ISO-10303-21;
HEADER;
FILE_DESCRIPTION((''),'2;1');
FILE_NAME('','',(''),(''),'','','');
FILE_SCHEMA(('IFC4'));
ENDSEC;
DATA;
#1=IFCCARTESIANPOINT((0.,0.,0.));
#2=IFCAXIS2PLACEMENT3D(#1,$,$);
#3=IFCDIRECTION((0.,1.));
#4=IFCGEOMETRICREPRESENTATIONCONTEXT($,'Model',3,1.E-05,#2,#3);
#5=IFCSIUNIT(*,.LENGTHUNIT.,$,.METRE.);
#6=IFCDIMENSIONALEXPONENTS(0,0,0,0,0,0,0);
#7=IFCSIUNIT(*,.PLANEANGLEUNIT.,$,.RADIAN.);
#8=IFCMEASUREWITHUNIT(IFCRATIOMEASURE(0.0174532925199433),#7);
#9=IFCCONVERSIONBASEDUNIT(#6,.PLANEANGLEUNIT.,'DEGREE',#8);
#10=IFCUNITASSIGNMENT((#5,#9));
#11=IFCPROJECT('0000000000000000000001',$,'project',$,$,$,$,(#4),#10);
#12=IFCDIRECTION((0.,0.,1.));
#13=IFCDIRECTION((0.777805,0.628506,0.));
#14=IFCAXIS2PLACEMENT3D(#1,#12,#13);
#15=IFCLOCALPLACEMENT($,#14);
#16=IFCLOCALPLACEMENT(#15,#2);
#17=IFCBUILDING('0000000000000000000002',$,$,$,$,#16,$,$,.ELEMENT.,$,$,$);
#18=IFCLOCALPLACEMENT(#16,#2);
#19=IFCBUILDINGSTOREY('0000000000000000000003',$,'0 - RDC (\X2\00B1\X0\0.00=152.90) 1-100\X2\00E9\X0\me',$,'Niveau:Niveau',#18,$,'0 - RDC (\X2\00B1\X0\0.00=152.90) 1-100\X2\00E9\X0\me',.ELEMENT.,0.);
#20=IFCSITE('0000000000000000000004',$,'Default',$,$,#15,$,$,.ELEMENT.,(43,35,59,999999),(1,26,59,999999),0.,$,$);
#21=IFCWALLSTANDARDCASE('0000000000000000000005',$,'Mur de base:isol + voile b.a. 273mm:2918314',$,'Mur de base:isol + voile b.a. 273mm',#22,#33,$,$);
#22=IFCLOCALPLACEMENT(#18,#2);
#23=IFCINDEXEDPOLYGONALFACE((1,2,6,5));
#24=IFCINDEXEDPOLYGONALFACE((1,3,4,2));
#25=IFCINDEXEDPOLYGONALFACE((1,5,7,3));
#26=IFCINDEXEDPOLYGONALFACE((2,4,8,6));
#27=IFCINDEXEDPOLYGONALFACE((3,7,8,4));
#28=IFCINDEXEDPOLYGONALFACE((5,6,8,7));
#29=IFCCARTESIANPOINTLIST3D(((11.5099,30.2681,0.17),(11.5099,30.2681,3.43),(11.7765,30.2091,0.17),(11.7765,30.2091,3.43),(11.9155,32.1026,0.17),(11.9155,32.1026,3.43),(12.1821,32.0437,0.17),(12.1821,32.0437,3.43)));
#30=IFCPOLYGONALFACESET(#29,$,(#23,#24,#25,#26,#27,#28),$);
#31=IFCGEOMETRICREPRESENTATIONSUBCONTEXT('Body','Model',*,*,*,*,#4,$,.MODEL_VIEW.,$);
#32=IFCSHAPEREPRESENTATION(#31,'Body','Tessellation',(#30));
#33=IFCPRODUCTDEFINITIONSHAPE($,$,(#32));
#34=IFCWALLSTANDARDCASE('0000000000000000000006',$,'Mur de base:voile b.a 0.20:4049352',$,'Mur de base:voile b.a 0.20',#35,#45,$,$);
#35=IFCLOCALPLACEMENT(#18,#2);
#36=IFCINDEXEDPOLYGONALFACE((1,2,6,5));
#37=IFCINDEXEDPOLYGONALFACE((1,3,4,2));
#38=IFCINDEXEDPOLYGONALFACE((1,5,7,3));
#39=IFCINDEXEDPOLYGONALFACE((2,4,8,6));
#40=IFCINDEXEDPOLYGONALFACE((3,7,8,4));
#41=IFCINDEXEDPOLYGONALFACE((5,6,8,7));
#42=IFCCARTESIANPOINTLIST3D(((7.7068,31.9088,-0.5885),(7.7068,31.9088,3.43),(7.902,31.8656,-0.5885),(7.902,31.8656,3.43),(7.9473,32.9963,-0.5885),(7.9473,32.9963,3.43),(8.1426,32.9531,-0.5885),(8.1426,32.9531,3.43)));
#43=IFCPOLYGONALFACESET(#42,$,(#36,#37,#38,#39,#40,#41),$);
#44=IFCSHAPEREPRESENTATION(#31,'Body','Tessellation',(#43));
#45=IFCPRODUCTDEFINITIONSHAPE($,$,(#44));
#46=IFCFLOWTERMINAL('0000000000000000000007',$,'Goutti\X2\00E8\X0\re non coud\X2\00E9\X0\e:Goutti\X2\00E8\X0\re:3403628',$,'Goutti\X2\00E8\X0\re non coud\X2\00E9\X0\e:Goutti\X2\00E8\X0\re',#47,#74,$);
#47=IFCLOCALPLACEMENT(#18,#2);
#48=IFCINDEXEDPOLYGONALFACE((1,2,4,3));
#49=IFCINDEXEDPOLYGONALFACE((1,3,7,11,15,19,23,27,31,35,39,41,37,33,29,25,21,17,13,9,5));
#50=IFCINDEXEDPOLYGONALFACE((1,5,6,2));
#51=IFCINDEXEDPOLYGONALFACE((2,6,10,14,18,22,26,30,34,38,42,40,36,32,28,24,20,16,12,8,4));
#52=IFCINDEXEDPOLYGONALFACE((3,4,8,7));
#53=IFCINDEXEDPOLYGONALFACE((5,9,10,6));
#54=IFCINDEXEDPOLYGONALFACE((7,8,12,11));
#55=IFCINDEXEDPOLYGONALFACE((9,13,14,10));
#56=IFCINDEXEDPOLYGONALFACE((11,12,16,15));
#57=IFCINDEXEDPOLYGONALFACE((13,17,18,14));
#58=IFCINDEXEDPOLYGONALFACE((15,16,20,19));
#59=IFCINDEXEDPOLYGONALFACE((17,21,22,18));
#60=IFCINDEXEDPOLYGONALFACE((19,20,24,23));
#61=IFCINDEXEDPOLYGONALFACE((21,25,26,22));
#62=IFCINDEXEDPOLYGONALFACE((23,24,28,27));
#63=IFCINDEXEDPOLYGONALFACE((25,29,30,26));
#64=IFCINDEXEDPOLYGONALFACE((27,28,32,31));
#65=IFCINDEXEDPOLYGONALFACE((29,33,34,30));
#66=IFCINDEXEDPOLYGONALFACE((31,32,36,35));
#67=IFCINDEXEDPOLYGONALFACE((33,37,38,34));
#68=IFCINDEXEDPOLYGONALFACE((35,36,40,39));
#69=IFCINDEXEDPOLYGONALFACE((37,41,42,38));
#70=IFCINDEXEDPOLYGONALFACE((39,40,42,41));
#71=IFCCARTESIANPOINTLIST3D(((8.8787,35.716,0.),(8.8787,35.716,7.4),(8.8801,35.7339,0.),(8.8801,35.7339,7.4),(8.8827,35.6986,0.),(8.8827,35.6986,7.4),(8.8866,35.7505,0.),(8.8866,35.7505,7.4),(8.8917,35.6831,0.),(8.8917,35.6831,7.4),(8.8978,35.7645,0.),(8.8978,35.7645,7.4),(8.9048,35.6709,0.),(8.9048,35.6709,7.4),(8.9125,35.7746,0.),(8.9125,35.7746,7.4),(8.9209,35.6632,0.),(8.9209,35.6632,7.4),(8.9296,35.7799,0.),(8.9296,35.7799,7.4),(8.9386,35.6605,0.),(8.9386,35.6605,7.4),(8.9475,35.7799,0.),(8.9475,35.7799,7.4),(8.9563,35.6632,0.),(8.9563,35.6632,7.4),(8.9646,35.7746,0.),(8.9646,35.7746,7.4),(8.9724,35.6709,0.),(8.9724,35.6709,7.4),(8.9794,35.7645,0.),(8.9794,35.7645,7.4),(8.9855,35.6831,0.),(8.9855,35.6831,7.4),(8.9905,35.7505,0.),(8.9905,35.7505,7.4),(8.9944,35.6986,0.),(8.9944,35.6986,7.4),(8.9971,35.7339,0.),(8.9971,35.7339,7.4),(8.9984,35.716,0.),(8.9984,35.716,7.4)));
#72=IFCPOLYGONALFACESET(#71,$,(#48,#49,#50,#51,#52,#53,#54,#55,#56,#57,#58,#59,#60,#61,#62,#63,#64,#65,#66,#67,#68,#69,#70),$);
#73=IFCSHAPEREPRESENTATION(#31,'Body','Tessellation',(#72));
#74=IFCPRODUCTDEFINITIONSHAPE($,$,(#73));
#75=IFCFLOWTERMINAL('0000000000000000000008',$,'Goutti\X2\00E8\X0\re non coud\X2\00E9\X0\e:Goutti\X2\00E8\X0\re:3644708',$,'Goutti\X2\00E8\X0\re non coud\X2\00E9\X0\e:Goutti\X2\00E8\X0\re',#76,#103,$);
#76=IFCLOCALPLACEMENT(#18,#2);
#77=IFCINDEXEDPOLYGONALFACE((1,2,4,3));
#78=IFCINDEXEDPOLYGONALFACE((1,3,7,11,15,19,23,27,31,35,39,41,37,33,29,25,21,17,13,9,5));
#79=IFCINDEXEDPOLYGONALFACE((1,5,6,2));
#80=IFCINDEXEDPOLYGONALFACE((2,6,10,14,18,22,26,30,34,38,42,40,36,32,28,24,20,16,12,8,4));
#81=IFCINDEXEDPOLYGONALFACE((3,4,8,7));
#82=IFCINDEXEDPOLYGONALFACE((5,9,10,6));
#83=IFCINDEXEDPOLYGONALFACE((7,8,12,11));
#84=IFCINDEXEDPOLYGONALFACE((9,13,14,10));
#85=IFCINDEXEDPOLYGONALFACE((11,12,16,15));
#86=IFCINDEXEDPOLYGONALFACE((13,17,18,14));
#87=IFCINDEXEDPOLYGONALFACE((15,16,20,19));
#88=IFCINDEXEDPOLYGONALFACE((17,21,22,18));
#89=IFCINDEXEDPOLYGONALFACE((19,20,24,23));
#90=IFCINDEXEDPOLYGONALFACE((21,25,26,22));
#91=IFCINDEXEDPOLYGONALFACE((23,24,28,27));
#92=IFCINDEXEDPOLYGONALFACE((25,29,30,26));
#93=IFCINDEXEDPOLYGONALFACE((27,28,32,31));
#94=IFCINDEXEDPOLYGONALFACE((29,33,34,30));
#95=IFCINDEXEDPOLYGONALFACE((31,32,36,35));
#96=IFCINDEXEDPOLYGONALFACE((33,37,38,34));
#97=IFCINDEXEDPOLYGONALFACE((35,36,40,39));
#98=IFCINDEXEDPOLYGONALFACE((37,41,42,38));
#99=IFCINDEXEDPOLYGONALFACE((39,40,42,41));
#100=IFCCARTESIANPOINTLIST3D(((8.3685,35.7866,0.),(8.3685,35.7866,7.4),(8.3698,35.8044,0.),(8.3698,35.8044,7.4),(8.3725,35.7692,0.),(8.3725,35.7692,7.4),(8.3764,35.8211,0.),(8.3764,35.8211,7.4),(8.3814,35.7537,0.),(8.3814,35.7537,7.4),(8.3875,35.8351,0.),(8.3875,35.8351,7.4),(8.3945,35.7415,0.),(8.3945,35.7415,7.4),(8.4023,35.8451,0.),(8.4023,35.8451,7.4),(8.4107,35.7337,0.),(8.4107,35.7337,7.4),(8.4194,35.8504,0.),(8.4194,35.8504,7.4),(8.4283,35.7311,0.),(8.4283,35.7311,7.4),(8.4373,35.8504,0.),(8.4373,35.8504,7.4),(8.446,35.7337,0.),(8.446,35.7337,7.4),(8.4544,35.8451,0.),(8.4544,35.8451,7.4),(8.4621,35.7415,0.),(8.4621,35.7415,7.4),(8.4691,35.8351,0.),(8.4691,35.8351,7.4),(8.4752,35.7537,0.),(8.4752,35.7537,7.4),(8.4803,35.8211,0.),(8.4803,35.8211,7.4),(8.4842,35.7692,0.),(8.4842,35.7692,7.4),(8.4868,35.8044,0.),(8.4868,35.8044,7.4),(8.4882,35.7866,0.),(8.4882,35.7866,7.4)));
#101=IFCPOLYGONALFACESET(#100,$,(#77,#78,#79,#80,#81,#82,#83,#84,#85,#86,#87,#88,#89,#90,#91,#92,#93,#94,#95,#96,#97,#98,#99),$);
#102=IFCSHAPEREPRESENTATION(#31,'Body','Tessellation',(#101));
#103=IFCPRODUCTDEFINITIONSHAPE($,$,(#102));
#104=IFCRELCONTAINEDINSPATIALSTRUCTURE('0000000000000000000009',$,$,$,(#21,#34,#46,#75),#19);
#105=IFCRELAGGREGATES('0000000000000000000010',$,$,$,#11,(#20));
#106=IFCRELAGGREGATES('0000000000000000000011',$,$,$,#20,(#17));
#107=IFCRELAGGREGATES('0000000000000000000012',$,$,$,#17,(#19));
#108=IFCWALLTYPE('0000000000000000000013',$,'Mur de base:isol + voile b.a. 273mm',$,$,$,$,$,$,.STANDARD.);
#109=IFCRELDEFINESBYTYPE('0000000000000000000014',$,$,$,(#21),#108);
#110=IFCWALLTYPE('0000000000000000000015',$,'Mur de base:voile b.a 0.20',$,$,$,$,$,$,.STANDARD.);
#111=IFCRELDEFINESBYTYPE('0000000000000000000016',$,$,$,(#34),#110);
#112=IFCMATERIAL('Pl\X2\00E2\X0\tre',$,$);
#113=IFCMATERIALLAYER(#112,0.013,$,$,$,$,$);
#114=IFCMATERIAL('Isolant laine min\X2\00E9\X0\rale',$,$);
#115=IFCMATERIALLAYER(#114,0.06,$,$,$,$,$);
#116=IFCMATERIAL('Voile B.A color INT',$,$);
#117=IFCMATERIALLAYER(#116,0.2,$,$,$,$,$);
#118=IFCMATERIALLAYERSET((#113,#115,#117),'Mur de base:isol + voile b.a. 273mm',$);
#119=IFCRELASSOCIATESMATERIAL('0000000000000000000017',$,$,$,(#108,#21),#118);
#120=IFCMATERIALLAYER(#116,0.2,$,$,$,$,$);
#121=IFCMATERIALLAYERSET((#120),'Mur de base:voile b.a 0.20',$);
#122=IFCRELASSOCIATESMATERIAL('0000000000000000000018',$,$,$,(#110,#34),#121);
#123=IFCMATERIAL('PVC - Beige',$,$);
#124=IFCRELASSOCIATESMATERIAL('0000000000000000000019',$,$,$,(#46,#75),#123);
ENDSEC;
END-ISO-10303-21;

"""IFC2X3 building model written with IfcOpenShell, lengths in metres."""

from ifc_helpers import new_model, entity, si_unit, converted_unit, direction, frame, frame_2d, origin, place, context, subcontext, project, spatial, polyline, rectangle, circle, outline, extrude, clip, bounded_halfspace, source, transform, mapped, material, layer, layer_set, layer_usage, type_object, element, save


model = new_model("IFC2X3")

# Units and contexts
model_context = context("Model", 3, precision=1e-05, world=origin(), true_north=direction((0.0, 1.0)))
body_context = subcontext(model_context, "Body", "Model", "MODEL_VIEW")
ifc_project = project(units=[si_unit("LENGTHUNIT", "METRE"), converted_unit("PLANEANGLEUNIT", "DEGREE", entity("IfcRatioMeasure", 0.0174532925199433), si_unit("PLANEANGLEUNIT", "RADIAN"), dimensions=[0, 0, 0, 0, 0, 0, 0])], contexts=[model_context])

# Site, building, storey
site_placement = place(None, frame((0.0, 0.0, 0.0), z_axis=(0.0, 0.0, 1.0), x_axis=(0.777805, 0.628506, 0.0)))
site = spatial("IfcSite", under=ifc_project, at=site_placement, Name="Default", CompositionType="ELEMENT", RefLatitude=(43, 35, 59, 999999), RefLongitude=(1, 26, 59, 999999), RefElevation=0.0)
building_placement = place(site_placement, origin())
building = spatial("IfcBuilding", under=site, at=building_placement, CompositionType="ELEMENT")
storey_placement = place(building_placement, origin())
storey = spatial("IfcBuildingStorey", under=building, at=storey_placement, Name="0 - RDC (±0.00=152.90) 1-100éme", ObjectType="Niveau:Niveau", LongName="0 - RDC (±0.00=152.90) 1-100éme", CompositionType="ELEMENT", Elevation=0.0)

# Shared definitions
ifc_material_1 = material(Name="Voile B.A color INT")

# Walls
ifc_material_2 = material(Name="Plâtre")
ifc_layer_1 = layer(ifc_material_2, 0.013)
ifc_material_3 = material(Name="Isolant laine minérale")
ifc_layer_2 = layer(ifc_material_3, 0.06)
ifc_layer_3 = layer(ifc_material_1, 0.2)
ifc_layer_set_1 = layer_set([ifc_layer_1, ifc_layer_2, ifc_layer_3], Name="Mur de base:isol + voile b.a. 273mm")
ifc_layer_usage_1 = layer_usage(ifc_layer_set_1, "AXIS2", "POSITIVE", -0.1365)
wall_type_1 = type_object("IfcWallType", Name="Mur de base:isol + voile b.a. 273mm", PredefinedType="STANDARD", material=ifc_layer_set_1)
wall_1_placement = place(storey_placement, frame((11.6432, 30.2386, 0.17), z_axis=(0.0, 0.0, 1.0), x_axis=(0.2159, 0.976415, 0.0)))
element("IfcWallStandardCase", 1, at=wall_1_placement, inside=storey, type_object=wall_type_1, material=ifc_layer_usage_1, Name="Mur de base:isol + voile b.a. 273mm:2918314", ObjectType="Mur de base:isol + voile b.a. 273mm", context=body_context, shape_type="Clipping", body=[
    clip(extrude(outline(polyline([(1.8789, -0.1365), (1.8789, 0.1365), (0.0, 0.1365), (0.0, -0.1365), (1.8789, -0.1365)])), origin(), (0.0, 0.0, 1.0), 3.26), bounded_halfspace(frame((1.8789, 0.0371, 3.26), z_axis=(0.0, 0.0, -1.0), x_axis=(0.976415, 0.2159, 0.0)), True, frame((1.8789, 0.0371, 3.26)), polyline([(0.0, 0.0), (0.0, 0.0994), (-1.1987, 0.0994), (-1.1987, -0.0016), (0.0, 0.0)]))),
])
ifc_layer_4 = layer(ifc_material_1, 0.2)
ifc_layer_set_2 = layer_set([ifc_layer_4], Name="Mur de base:voile b.a 0.20")
ifc_layer_usage_2 = layer_usage(ifc_layer_set_2, "AXIS2", "NEGATIVE", 0.1)
wall_type_2 = type_object("IfcWallType", Name="Mur de base:voile b.a 0.20", PredefinedType="STANDARD", material=ifc_layer_set_2)
wall_2_placement = place(storey_placement, frame((8.045, 32.9747, -0.5885), z_axis=(0.0, 0.0, 1.0), x_axis=(-0.215985, -0.976397, 0.0)))
element("IfcWallStandardCase", 2, at=wall_2_placement, inside=storey, type_object=wall_type_2, material=ifc_layer_usage_2, Name="Mur de base:voile b.a 0.20:4049352", ObjectType="Mur de base:voile b.a 0.20", context=body_context, shape_type="SweptSolid", body=[
    extrude(rectangle(XDim=1.1138, YDim=0.2, at=frame_2d((0.5569, 0.0), x_axis=(-1.0, 0.0))), origin(), (0.0, 0.0, 1.0), 4.0185),
])

# Flow terminals
ifc_material_4 = material(Name="PVC - Beige")
shared_shape_1 = source(origin(), body_context, "Body", "SweptSolid", [
    extrude(circle(Radius=0.06, at=frame_2d((0.0, 0.0), x_axis=(1.0, 0.0))), frame((0.0, 0.0, 0.0), z_axis=(0.0, 0.0, 1.0), x_axis=(0.0, -1.0, 0.0)), (0.0, 0.0, 1.0), 7.4),
])
for number, where, name in (
    (3, (8.9386, 35.7205, 0.0), "Gouttière non coudée:Gouttière:3403628"),
    (4, (8.4283, 35.7911, 0.0), "Gouttière non coudée:Gouttière:3644708"),
):
    element("IfcFlowTerminal", number, at=place(storey_placement, frame(where)), inside=storey, material=ifc_material_4, Name=name, ObjectType="Gouttière non coudée:Gouttière", context=body_context, shape_type="MappedRepresentation", body=[
        mapped(shared_shape_1, transform((0.0, 0.0, 0.0), scale=1.0)),
    ])

save(model, "model.ifc")
